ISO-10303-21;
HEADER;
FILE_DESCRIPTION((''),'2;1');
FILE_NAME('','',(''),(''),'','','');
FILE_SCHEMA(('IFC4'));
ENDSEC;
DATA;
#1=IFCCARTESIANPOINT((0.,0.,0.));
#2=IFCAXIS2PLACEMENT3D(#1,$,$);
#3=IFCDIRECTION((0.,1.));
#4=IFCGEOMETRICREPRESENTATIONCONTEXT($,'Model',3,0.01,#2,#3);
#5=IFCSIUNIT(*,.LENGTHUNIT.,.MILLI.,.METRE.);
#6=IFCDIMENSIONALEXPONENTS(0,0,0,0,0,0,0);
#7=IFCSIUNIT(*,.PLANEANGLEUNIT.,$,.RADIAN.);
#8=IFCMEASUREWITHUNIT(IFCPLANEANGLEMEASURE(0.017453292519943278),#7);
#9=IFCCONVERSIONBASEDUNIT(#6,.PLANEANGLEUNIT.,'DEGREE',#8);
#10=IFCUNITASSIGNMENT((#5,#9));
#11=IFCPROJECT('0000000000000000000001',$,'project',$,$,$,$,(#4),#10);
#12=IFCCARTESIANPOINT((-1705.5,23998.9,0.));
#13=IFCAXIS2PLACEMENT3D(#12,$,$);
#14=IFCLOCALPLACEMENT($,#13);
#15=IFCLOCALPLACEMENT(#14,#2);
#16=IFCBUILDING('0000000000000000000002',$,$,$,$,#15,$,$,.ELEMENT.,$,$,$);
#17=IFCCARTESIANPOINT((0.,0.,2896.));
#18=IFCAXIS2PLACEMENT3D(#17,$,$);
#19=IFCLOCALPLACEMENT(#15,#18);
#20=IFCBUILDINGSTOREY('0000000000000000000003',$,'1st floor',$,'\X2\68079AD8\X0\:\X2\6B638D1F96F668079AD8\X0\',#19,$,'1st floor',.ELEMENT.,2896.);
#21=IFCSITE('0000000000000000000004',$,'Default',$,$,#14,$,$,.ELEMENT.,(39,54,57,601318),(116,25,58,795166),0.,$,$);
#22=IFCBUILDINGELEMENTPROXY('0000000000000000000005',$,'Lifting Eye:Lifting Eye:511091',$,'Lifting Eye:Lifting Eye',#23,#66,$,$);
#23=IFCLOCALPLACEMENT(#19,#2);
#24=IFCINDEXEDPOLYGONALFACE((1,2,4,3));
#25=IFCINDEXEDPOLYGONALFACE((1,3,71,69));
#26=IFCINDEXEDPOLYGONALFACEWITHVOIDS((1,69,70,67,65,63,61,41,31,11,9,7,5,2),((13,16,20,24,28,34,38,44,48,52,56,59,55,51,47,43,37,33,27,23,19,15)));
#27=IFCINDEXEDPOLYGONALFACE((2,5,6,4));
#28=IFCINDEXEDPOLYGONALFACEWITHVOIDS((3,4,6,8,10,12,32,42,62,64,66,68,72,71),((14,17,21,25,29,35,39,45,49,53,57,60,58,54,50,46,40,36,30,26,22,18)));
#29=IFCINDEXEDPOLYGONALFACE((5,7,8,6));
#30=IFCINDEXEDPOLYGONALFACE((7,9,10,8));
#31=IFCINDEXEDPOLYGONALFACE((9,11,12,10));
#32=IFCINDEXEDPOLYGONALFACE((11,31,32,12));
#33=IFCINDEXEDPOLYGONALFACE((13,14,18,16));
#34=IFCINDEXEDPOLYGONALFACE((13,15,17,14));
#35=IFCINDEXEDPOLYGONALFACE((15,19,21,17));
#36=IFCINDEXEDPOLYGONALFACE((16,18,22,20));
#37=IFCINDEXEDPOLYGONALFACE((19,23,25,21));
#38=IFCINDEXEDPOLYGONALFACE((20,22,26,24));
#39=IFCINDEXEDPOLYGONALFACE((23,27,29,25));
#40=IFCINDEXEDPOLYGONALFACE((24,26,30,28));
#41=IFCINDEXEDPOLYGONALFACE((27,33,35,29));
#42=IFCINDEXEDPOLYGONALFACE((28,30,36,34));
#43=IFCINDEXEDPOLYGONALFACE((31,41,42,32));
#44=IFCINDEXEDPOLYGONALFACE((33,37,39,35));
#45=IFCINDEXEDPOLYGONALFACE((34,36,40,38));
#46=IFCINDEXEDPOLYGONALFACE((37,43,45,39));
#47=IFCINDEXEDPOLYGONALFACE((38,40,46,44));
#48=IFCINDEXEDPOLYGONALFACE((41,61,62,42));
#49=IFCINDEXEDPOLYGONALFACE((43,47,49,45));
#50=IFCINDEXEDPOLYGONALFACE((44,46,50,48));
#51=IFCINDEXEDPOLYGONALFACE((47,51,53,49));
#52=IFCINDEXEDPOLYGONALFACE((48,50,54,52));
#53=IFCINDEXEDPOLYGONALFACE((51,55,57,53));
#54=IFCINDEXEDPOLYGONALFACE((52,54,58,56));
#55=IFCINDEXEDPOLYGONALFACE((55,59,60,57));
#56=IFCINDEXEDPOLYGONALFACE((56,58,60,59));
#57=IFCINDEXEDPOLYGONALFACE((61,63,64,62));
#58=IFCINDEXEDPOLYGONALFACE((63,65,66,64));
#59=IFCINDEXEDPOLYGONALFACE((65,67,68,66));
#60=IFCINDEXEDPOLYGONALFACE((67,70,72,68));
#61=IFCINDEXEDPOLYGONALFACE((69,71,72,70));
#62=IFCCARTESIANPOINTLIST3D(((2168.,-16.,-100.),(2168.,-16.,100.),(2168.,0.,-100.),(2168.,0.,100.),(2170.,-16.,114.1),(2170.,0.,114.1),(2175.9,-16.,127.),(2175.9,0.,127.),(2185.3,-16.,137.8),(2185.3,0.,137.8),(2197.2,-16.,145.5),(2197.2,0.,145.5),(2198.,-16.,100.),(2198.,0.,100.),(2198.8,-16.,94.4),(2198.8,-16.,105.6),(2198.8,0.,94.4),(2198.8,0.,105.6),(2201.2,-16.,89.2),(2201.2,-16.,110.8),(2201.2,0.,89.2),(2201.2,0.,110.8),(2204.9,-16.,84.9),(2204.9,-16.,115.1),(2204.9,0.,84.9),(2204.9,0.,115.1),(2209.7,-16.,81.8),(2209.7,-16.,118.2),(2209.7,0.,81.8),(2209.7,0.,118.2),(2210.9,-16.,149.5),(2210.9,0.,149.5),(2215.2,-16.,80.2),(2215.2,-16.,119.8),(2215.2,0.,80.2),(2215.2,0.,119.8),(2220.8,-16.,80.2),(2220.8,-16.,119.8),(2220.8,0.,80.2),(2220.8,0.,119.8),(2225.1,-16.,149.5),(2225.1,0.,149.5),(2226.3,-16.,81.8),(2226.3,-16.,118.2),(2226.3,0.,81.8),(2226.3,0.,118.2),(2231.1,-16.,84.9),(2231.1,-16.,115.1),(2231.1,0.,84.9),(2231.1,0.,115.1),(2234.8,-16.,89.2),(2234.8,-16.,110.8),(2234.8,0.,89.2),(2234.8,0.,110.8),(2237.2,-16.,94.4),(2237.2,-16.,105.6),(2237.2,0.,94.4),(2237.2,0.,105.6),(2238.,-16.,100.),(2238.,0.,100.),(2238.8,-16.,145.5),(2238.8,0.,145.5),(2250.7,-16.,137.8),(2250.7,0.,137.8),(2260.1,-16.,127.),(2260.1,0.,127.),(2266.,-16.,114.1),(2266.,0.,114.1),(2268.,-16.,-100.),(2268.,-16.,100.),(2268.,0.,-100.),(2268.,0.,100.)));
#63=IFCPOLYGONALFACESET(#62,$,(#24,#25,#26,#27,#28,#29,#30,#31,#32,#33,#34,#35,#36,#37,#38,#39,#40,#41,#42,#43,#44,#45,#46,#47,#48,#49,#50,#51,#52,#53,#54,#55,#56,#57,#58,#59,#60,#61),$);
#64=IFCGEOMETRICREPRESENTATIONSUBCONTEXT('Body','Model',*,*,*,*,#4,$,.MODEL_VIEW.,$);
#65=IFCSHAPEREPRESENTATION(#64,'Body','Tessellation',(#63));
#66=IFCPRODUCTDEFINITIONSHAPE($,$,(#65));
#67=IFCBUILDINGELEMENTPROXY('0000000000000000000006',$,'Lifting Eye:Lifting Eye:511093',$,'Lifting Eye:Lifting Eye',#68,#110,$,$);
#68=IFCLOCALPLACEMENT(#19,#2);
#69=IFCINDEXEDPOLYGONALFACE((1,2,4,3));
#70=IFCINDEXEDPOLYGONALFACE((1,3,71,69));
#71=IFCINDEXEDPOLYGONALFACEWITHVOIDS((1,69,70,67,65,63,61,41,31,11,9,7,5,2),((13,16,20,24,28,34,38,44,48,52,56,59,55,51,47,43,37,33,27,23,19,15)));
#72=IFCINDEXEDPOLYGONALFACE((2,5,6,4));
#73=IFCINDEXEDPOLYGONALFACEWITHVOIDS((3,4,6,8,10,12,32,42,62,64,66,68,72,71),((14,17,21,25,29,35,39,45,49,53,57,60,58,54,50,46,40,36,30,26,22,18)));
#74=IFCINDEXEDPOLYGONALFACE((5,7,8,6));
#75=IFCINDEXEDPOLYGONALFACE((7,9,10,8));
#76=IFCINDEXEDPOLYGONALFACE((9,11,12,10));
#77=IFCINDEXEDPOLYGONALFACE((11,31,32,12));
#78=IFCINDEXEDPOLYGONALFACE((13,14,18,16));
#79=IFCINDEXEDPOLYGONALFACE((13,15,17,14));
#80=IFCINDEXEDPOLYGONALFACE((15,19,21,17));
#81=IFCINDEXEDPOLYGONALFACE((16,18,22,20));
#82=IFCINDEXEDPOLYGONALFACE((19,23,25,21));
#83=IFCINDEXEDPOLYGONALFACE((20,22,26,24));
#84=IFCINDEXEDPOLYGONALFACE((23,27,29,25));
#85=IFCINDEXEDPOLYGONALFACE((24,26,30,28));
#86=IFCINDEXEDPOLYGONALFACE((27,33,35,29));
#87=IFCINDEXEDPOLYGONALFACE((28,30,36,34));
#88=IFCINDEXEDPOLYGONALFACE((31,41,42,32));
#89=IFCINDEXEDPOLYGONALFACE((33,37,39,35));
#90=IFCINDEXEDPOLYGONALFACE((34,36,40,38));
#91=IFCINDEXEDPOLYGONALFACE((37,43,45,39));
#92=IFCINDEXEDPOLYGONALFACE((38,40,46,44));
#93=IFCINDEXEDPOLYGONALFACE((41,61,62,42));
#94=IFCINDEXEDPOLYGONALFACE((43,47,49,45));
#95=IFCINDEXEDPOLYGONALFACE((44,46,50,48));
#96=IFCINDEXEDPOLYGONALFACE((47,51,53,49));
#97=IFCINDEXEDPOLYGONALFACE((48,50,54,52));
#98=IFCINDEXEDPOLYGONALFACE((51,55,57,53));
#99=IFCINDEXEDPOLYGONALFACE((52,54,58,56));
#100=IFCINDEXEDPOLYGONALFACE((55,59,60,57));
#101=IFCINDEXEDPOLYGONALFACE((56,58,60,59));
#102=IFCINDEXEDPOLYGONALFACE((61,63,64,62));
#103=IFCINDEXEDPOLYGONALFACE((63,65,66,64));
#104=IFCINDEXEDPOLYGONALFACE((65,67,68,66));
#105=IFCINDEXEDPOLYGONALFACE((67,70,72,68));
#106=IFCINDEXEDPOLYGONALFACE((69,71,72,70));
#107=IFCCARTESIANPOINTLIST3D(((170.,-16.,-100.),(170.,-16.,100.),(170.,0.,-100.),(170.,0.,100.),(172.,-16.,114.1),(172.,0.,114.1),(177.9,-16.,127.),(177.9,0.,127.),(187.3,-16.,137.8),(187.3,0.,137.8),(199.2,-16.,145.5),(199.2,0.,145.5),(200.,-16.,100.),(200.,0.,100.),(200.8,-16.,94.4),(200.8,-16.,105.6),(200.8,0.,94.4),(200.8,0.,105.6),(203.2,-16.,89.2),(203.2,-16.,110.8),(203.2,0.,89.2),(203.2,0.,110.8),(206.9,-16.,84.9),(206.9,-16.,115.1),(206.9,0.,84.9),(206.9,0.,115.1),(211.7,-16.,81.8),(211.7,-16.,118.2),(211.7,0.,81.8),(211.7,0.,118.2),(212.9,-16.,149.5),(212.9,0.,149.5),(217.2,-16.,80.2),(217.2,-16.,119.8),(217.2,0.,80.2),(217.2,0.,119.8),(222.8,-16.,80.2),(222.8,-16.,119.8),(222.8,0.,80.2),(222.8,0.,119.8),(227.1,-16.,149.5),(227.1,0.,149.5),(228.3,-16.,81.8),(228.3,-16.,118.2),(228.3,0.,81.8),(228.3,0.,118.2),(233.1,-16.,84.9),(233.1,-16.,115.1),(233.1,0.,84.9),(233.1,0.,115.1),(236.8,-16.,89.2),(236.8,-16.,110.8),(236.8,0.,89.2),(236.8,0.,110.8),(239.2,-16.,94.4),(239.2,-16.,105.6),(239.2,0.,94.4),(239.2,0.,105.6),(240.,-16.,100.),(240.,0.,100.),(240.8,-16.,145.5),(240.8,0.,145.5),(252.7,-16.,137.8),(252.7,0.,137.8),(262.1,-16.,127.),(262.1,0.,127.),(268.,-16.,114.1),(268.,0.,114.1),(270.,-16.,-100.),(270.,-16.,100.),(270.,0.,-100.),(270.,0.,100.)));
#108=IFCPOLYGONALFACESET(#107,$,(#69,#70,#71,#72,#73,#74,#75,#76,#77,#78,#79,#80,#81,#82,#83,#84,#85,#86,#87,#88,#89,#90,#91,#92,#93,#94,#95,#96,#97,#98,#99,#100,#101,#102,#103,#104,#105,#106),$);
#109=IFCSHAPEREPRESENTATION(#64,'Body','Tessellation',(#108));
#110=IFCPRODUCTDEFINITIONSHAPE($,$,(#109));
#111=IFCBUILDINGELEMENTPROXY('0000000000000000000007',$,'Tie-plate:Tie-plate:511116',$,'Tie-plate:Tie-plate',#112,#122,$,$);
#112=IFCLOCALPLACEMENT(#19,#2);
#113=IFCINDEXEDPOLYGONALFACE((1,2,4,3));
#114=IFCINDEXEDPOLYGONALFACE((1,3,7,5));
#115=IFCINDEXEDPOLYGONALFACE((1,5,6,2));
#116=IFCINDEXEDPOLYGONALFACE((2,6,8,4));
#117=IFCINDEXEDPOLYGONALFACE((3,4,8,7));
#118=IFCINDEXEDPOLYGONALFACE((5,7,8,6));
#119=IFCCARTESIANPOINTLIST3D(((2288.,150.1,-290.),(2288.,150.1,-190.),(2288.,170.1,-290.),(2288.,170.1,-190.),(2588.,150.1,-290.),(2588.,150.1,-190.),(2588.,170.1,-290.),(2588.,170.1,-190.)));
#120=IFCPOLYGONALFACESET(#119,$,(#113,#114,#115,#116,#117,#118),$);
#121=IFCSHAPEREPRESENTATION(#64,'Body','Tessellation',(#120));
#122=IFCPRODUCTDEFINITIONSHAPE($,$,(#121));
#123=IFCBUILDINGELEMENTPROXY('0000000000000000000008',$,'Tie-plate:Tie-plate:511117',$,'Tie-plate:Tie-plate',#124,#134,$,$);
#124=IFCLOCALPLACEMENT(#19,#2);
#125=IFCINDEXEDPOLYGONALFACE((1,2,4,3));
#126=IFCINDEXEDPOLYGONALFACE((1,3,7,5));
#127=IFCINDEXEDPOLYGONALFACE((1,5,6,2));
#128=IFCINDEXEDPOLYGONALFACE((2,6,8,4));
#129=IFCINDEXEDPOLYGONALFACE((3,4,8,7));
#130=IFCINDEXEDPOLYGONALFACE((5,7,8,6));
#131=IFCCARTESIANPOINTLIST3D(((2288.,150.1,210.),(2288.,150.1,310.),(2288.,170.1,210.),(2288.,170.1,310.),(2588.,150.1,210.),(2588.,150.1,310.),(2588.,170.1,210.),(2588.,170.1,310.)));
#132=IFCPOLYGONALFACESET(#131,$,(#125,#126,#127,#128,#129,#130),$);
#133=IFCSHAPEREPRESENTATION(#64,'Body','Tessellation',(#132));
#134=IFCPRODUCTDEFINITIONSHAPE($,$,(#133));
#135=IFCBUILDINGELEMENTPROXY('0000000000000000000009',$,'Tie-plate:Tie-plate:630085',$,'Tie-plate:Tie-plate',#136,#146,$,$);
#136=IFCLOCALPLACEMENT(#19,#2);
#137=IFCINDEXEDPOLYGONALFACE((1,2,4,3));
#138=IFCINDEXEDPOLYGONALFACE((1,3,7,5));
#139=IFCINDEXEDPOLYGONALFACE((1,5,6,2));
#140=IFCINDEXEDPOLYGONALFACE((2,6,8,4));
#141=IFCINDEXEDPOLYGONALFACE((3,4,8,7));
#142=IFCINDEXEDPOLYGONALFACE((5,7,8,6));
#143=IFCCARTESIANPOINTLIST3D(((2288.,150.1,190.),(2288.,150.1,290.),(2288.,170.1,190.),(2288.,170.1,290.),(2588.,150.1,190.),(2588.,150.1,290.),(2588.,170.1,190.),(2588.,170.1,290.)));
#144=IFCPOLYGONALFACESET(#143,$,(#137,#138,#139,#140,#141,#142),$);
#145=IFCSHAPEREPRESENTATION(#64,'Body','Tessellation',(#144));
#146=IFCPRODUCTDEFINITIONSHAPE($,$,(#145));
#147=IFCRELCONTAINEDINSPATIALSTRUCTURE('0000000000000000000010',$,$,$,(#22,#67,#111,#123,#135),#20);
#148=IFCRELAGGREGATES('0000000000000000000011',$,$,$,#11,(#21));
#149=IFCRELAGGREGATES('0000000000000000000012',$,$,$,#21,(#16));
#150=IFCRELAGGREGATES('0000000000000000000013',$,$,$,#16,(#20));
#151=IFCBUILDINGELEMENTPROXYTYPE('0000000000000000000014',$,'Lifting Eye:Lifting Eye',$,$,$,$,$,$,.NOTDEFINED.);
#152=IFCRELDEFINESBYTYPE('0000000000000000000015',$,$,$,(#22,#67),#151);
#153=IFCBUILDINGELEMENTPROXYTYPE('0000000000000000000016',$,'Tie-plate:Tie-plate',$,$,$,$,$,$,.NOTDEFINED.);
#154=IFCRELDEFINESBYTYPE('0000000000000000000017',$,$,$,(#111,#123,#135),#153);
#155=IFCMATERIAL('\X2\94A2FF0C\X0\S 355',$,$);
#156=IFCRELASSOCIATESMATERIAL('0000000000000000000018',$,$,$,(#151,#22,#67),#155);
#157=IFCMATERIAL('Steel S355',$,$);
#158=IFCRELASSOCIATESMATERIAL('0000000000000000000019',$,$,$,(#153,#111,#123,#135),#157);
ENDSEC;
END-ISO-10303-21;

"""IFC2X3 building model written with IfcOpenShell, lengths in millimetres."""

from ifc_helpers import new_model, entity, si_unit, converted_unit, direction, frame, frame_2d, origin, place, context, subcontext, project, spatial, polyline, circle_curve, parameter, trimmed, segment, composite_curve, rectangle, outline, extrude, source, transform, mapped, material, type_object, type_shapes, element, save


model = new_model("IFC2X3")

# Units and contexts
model_context = context("Model", 3, precision=0.01, world=origin(), true_north=direction((0.0, 1.0)))
body_context = subcontext(model_context, "Body", "Model", "MODEL_VIEW")
ifc_project = project(units=[si_unit("LENGTHUNIT", "METRE", prefix="MILLI"), converted_unit("PLANEANGLEUNIT", "DEGREE", entity("IfcPlaneAngleMeasure", 0.017453292519943278), si_unit("PLANEANGLEUNIT", "RADIAN"), dimensions=[0, 0, 0, 0, 0, 0, 0])], contexts=[model_context])

# Site, building, storey
site_placement = place(None, frame((-1705.5, 23998.9, 0.0)))
site = spatial("IfcSite", under=ifc_project, at=site_placement, Name="Default", CompositionType="ELEMENT", RefLatitude=(39, 54, 57, 601318), RefLongitude=(116, 25, 58, 795166), RefElevation=0.0)
building_placement = place(site_placement, origin())
building = spatial("IfcBuilding", under=site, at=building_placement, CompositionType="ELEMENT")
storey_placement = place(building_placement, frame((0.0, 0.0, 2896.0)))
storey = spatial("IfcBuildingStorey", under=building, at=storey_placement, Name="1st floor", ObjectType="标高:正负零标高", LongName="1st floor", CompositionType="ELEMENT", Elevation=2896.0)

# Shared definitions
ifc_material_1 = material(Name="Steel S355")

# Building element proxies
ifc_material_2 = material(Name="钢，S 355")
building_element_proxy_type_1 = type_object("IfcBuildingElementProxyType", Name="Lifting Eye:Lifting Eye", PredefinedType="NOTDEFINED", material=ifc_material_2)
shared_shape_1 = source(origin(), body_context, "Body", "SweptSolid", [
    extrude(outline(composite_curve([segment(polyline([(-100.0, -50.0), (100.0, -50.0)]), True, "CONTINUOUS"), segment(polyline([(100.0, -50.0), (100.0, 50.0)]), True, "CONTINUOUS"), segment(polyline([(100.0, 50.0), (-100.0, 50.0)]), True, "CONTINUOUS"), segment(trimmed(circle_curve(frame_2d((-100.0, 0.0), x_axis=(0.0, -1.0)), 50.0), [parameter(180.0)], [parameter(0.0)], True, "PARAMETER"), True, "CONTINUOUS")], self_intersect=False), holes=[composite_curve([segment(trimmed(circle_curve(frame_2d((-100.0, 0.0), x_axis=(0.0, -1.0)), 20.0), [parameter(180.0)], [parameter(360.0)], True, "PARAMETER"), False, "CONTINUOUS"), segment(trimmed(circle_curve(frame_2d((-100.0, 0.0), x_axis=(0.0, -1.0)), 20.0), [parameter(0.0)], [parameter(180.0)], True, "PARAMETER"), False, "CONTINUOUS")], self_intersect=False)]), frame((0.0, 17.0, -17.0), z_axis=(0.0, 1.0, 0.0), x_axis=(0.0, 0.0, -1.0)), (0.0, 0.0, 1.0), 16.0),
])
type_shapes(building_element_proxy_type_1, [shared_shape_1])
for number, where, name in (
    (1, (2218.0, -33.0, 17.0), "Lifting Eye:Lifting Eye:511091"),
    (2, (220.0, -33.0, 17.0), "Lifting Eye:Lifting Eye:511093"),
):
    element("IfcBuildingElementProxy", number, at=place(storey_placement, frame(where)), inside=storey, type_object=building_element_proxy_type_1, material=ifc_material_2, Name=name, ObjectType="Lifting Eye:Lifting Eye", context=body_context, shape_type="MappedRepresentation", body=[
        mapped(shared_shape_1, transform((0.0, 0.0, 0.0), scale=1.0)),
    ])
building_element_proxy_type_2 = type_object("IfcBuildingElementProxyType", Name="Tie-plate:Tie-plate", PredefinedType="NOTDEFINED", material=ifc_material_1)
shared_shape_2 = source(origin(), body_context, "Body", "SweptSolid", [
    extrude(rectangle(XDim=20.0, YDim=300.0, at=frame_2d((0.0, 0.0), x_axis=(1.0, 0.0))), frame((150.0, 10.0, 0.0), z_axis=(0.0, 0.0, 1.0), x_axis=(0.0, 1.0, 0.0)), (0.0, 0.0, 1.0), 100.0),
])
type_shapes(building_element_proxy_type_2, [shared_shape_2])
for number, where, name in (
    (3, (2288.0, 150.1, -290.0), "Tie-plate:Tie-plate:511116"),
    (4, (2288.0, 150.1, 210.0), "Tie-plate:Tie-plate:511117"),
    (5, (2288.0, 150.1, 190.0), "Tie-plate:Tie-plate:630085"),
):
    element("IfcBuildingElementProxy", number, at=place(storey_placement, frame(where)), inside=storey, type_object=building_element_proxy_type_2, material=ifc_material_1, Name=name, ObjectType="Tie-plate:Tie-plate", context=body_context, shape_type="MappedRepresentation", body=[
        mapped(shared_shape_2, transform((0.0, 0.0, 0.0), scale=1.0)),
    ])

save(model, "model.ifc")
